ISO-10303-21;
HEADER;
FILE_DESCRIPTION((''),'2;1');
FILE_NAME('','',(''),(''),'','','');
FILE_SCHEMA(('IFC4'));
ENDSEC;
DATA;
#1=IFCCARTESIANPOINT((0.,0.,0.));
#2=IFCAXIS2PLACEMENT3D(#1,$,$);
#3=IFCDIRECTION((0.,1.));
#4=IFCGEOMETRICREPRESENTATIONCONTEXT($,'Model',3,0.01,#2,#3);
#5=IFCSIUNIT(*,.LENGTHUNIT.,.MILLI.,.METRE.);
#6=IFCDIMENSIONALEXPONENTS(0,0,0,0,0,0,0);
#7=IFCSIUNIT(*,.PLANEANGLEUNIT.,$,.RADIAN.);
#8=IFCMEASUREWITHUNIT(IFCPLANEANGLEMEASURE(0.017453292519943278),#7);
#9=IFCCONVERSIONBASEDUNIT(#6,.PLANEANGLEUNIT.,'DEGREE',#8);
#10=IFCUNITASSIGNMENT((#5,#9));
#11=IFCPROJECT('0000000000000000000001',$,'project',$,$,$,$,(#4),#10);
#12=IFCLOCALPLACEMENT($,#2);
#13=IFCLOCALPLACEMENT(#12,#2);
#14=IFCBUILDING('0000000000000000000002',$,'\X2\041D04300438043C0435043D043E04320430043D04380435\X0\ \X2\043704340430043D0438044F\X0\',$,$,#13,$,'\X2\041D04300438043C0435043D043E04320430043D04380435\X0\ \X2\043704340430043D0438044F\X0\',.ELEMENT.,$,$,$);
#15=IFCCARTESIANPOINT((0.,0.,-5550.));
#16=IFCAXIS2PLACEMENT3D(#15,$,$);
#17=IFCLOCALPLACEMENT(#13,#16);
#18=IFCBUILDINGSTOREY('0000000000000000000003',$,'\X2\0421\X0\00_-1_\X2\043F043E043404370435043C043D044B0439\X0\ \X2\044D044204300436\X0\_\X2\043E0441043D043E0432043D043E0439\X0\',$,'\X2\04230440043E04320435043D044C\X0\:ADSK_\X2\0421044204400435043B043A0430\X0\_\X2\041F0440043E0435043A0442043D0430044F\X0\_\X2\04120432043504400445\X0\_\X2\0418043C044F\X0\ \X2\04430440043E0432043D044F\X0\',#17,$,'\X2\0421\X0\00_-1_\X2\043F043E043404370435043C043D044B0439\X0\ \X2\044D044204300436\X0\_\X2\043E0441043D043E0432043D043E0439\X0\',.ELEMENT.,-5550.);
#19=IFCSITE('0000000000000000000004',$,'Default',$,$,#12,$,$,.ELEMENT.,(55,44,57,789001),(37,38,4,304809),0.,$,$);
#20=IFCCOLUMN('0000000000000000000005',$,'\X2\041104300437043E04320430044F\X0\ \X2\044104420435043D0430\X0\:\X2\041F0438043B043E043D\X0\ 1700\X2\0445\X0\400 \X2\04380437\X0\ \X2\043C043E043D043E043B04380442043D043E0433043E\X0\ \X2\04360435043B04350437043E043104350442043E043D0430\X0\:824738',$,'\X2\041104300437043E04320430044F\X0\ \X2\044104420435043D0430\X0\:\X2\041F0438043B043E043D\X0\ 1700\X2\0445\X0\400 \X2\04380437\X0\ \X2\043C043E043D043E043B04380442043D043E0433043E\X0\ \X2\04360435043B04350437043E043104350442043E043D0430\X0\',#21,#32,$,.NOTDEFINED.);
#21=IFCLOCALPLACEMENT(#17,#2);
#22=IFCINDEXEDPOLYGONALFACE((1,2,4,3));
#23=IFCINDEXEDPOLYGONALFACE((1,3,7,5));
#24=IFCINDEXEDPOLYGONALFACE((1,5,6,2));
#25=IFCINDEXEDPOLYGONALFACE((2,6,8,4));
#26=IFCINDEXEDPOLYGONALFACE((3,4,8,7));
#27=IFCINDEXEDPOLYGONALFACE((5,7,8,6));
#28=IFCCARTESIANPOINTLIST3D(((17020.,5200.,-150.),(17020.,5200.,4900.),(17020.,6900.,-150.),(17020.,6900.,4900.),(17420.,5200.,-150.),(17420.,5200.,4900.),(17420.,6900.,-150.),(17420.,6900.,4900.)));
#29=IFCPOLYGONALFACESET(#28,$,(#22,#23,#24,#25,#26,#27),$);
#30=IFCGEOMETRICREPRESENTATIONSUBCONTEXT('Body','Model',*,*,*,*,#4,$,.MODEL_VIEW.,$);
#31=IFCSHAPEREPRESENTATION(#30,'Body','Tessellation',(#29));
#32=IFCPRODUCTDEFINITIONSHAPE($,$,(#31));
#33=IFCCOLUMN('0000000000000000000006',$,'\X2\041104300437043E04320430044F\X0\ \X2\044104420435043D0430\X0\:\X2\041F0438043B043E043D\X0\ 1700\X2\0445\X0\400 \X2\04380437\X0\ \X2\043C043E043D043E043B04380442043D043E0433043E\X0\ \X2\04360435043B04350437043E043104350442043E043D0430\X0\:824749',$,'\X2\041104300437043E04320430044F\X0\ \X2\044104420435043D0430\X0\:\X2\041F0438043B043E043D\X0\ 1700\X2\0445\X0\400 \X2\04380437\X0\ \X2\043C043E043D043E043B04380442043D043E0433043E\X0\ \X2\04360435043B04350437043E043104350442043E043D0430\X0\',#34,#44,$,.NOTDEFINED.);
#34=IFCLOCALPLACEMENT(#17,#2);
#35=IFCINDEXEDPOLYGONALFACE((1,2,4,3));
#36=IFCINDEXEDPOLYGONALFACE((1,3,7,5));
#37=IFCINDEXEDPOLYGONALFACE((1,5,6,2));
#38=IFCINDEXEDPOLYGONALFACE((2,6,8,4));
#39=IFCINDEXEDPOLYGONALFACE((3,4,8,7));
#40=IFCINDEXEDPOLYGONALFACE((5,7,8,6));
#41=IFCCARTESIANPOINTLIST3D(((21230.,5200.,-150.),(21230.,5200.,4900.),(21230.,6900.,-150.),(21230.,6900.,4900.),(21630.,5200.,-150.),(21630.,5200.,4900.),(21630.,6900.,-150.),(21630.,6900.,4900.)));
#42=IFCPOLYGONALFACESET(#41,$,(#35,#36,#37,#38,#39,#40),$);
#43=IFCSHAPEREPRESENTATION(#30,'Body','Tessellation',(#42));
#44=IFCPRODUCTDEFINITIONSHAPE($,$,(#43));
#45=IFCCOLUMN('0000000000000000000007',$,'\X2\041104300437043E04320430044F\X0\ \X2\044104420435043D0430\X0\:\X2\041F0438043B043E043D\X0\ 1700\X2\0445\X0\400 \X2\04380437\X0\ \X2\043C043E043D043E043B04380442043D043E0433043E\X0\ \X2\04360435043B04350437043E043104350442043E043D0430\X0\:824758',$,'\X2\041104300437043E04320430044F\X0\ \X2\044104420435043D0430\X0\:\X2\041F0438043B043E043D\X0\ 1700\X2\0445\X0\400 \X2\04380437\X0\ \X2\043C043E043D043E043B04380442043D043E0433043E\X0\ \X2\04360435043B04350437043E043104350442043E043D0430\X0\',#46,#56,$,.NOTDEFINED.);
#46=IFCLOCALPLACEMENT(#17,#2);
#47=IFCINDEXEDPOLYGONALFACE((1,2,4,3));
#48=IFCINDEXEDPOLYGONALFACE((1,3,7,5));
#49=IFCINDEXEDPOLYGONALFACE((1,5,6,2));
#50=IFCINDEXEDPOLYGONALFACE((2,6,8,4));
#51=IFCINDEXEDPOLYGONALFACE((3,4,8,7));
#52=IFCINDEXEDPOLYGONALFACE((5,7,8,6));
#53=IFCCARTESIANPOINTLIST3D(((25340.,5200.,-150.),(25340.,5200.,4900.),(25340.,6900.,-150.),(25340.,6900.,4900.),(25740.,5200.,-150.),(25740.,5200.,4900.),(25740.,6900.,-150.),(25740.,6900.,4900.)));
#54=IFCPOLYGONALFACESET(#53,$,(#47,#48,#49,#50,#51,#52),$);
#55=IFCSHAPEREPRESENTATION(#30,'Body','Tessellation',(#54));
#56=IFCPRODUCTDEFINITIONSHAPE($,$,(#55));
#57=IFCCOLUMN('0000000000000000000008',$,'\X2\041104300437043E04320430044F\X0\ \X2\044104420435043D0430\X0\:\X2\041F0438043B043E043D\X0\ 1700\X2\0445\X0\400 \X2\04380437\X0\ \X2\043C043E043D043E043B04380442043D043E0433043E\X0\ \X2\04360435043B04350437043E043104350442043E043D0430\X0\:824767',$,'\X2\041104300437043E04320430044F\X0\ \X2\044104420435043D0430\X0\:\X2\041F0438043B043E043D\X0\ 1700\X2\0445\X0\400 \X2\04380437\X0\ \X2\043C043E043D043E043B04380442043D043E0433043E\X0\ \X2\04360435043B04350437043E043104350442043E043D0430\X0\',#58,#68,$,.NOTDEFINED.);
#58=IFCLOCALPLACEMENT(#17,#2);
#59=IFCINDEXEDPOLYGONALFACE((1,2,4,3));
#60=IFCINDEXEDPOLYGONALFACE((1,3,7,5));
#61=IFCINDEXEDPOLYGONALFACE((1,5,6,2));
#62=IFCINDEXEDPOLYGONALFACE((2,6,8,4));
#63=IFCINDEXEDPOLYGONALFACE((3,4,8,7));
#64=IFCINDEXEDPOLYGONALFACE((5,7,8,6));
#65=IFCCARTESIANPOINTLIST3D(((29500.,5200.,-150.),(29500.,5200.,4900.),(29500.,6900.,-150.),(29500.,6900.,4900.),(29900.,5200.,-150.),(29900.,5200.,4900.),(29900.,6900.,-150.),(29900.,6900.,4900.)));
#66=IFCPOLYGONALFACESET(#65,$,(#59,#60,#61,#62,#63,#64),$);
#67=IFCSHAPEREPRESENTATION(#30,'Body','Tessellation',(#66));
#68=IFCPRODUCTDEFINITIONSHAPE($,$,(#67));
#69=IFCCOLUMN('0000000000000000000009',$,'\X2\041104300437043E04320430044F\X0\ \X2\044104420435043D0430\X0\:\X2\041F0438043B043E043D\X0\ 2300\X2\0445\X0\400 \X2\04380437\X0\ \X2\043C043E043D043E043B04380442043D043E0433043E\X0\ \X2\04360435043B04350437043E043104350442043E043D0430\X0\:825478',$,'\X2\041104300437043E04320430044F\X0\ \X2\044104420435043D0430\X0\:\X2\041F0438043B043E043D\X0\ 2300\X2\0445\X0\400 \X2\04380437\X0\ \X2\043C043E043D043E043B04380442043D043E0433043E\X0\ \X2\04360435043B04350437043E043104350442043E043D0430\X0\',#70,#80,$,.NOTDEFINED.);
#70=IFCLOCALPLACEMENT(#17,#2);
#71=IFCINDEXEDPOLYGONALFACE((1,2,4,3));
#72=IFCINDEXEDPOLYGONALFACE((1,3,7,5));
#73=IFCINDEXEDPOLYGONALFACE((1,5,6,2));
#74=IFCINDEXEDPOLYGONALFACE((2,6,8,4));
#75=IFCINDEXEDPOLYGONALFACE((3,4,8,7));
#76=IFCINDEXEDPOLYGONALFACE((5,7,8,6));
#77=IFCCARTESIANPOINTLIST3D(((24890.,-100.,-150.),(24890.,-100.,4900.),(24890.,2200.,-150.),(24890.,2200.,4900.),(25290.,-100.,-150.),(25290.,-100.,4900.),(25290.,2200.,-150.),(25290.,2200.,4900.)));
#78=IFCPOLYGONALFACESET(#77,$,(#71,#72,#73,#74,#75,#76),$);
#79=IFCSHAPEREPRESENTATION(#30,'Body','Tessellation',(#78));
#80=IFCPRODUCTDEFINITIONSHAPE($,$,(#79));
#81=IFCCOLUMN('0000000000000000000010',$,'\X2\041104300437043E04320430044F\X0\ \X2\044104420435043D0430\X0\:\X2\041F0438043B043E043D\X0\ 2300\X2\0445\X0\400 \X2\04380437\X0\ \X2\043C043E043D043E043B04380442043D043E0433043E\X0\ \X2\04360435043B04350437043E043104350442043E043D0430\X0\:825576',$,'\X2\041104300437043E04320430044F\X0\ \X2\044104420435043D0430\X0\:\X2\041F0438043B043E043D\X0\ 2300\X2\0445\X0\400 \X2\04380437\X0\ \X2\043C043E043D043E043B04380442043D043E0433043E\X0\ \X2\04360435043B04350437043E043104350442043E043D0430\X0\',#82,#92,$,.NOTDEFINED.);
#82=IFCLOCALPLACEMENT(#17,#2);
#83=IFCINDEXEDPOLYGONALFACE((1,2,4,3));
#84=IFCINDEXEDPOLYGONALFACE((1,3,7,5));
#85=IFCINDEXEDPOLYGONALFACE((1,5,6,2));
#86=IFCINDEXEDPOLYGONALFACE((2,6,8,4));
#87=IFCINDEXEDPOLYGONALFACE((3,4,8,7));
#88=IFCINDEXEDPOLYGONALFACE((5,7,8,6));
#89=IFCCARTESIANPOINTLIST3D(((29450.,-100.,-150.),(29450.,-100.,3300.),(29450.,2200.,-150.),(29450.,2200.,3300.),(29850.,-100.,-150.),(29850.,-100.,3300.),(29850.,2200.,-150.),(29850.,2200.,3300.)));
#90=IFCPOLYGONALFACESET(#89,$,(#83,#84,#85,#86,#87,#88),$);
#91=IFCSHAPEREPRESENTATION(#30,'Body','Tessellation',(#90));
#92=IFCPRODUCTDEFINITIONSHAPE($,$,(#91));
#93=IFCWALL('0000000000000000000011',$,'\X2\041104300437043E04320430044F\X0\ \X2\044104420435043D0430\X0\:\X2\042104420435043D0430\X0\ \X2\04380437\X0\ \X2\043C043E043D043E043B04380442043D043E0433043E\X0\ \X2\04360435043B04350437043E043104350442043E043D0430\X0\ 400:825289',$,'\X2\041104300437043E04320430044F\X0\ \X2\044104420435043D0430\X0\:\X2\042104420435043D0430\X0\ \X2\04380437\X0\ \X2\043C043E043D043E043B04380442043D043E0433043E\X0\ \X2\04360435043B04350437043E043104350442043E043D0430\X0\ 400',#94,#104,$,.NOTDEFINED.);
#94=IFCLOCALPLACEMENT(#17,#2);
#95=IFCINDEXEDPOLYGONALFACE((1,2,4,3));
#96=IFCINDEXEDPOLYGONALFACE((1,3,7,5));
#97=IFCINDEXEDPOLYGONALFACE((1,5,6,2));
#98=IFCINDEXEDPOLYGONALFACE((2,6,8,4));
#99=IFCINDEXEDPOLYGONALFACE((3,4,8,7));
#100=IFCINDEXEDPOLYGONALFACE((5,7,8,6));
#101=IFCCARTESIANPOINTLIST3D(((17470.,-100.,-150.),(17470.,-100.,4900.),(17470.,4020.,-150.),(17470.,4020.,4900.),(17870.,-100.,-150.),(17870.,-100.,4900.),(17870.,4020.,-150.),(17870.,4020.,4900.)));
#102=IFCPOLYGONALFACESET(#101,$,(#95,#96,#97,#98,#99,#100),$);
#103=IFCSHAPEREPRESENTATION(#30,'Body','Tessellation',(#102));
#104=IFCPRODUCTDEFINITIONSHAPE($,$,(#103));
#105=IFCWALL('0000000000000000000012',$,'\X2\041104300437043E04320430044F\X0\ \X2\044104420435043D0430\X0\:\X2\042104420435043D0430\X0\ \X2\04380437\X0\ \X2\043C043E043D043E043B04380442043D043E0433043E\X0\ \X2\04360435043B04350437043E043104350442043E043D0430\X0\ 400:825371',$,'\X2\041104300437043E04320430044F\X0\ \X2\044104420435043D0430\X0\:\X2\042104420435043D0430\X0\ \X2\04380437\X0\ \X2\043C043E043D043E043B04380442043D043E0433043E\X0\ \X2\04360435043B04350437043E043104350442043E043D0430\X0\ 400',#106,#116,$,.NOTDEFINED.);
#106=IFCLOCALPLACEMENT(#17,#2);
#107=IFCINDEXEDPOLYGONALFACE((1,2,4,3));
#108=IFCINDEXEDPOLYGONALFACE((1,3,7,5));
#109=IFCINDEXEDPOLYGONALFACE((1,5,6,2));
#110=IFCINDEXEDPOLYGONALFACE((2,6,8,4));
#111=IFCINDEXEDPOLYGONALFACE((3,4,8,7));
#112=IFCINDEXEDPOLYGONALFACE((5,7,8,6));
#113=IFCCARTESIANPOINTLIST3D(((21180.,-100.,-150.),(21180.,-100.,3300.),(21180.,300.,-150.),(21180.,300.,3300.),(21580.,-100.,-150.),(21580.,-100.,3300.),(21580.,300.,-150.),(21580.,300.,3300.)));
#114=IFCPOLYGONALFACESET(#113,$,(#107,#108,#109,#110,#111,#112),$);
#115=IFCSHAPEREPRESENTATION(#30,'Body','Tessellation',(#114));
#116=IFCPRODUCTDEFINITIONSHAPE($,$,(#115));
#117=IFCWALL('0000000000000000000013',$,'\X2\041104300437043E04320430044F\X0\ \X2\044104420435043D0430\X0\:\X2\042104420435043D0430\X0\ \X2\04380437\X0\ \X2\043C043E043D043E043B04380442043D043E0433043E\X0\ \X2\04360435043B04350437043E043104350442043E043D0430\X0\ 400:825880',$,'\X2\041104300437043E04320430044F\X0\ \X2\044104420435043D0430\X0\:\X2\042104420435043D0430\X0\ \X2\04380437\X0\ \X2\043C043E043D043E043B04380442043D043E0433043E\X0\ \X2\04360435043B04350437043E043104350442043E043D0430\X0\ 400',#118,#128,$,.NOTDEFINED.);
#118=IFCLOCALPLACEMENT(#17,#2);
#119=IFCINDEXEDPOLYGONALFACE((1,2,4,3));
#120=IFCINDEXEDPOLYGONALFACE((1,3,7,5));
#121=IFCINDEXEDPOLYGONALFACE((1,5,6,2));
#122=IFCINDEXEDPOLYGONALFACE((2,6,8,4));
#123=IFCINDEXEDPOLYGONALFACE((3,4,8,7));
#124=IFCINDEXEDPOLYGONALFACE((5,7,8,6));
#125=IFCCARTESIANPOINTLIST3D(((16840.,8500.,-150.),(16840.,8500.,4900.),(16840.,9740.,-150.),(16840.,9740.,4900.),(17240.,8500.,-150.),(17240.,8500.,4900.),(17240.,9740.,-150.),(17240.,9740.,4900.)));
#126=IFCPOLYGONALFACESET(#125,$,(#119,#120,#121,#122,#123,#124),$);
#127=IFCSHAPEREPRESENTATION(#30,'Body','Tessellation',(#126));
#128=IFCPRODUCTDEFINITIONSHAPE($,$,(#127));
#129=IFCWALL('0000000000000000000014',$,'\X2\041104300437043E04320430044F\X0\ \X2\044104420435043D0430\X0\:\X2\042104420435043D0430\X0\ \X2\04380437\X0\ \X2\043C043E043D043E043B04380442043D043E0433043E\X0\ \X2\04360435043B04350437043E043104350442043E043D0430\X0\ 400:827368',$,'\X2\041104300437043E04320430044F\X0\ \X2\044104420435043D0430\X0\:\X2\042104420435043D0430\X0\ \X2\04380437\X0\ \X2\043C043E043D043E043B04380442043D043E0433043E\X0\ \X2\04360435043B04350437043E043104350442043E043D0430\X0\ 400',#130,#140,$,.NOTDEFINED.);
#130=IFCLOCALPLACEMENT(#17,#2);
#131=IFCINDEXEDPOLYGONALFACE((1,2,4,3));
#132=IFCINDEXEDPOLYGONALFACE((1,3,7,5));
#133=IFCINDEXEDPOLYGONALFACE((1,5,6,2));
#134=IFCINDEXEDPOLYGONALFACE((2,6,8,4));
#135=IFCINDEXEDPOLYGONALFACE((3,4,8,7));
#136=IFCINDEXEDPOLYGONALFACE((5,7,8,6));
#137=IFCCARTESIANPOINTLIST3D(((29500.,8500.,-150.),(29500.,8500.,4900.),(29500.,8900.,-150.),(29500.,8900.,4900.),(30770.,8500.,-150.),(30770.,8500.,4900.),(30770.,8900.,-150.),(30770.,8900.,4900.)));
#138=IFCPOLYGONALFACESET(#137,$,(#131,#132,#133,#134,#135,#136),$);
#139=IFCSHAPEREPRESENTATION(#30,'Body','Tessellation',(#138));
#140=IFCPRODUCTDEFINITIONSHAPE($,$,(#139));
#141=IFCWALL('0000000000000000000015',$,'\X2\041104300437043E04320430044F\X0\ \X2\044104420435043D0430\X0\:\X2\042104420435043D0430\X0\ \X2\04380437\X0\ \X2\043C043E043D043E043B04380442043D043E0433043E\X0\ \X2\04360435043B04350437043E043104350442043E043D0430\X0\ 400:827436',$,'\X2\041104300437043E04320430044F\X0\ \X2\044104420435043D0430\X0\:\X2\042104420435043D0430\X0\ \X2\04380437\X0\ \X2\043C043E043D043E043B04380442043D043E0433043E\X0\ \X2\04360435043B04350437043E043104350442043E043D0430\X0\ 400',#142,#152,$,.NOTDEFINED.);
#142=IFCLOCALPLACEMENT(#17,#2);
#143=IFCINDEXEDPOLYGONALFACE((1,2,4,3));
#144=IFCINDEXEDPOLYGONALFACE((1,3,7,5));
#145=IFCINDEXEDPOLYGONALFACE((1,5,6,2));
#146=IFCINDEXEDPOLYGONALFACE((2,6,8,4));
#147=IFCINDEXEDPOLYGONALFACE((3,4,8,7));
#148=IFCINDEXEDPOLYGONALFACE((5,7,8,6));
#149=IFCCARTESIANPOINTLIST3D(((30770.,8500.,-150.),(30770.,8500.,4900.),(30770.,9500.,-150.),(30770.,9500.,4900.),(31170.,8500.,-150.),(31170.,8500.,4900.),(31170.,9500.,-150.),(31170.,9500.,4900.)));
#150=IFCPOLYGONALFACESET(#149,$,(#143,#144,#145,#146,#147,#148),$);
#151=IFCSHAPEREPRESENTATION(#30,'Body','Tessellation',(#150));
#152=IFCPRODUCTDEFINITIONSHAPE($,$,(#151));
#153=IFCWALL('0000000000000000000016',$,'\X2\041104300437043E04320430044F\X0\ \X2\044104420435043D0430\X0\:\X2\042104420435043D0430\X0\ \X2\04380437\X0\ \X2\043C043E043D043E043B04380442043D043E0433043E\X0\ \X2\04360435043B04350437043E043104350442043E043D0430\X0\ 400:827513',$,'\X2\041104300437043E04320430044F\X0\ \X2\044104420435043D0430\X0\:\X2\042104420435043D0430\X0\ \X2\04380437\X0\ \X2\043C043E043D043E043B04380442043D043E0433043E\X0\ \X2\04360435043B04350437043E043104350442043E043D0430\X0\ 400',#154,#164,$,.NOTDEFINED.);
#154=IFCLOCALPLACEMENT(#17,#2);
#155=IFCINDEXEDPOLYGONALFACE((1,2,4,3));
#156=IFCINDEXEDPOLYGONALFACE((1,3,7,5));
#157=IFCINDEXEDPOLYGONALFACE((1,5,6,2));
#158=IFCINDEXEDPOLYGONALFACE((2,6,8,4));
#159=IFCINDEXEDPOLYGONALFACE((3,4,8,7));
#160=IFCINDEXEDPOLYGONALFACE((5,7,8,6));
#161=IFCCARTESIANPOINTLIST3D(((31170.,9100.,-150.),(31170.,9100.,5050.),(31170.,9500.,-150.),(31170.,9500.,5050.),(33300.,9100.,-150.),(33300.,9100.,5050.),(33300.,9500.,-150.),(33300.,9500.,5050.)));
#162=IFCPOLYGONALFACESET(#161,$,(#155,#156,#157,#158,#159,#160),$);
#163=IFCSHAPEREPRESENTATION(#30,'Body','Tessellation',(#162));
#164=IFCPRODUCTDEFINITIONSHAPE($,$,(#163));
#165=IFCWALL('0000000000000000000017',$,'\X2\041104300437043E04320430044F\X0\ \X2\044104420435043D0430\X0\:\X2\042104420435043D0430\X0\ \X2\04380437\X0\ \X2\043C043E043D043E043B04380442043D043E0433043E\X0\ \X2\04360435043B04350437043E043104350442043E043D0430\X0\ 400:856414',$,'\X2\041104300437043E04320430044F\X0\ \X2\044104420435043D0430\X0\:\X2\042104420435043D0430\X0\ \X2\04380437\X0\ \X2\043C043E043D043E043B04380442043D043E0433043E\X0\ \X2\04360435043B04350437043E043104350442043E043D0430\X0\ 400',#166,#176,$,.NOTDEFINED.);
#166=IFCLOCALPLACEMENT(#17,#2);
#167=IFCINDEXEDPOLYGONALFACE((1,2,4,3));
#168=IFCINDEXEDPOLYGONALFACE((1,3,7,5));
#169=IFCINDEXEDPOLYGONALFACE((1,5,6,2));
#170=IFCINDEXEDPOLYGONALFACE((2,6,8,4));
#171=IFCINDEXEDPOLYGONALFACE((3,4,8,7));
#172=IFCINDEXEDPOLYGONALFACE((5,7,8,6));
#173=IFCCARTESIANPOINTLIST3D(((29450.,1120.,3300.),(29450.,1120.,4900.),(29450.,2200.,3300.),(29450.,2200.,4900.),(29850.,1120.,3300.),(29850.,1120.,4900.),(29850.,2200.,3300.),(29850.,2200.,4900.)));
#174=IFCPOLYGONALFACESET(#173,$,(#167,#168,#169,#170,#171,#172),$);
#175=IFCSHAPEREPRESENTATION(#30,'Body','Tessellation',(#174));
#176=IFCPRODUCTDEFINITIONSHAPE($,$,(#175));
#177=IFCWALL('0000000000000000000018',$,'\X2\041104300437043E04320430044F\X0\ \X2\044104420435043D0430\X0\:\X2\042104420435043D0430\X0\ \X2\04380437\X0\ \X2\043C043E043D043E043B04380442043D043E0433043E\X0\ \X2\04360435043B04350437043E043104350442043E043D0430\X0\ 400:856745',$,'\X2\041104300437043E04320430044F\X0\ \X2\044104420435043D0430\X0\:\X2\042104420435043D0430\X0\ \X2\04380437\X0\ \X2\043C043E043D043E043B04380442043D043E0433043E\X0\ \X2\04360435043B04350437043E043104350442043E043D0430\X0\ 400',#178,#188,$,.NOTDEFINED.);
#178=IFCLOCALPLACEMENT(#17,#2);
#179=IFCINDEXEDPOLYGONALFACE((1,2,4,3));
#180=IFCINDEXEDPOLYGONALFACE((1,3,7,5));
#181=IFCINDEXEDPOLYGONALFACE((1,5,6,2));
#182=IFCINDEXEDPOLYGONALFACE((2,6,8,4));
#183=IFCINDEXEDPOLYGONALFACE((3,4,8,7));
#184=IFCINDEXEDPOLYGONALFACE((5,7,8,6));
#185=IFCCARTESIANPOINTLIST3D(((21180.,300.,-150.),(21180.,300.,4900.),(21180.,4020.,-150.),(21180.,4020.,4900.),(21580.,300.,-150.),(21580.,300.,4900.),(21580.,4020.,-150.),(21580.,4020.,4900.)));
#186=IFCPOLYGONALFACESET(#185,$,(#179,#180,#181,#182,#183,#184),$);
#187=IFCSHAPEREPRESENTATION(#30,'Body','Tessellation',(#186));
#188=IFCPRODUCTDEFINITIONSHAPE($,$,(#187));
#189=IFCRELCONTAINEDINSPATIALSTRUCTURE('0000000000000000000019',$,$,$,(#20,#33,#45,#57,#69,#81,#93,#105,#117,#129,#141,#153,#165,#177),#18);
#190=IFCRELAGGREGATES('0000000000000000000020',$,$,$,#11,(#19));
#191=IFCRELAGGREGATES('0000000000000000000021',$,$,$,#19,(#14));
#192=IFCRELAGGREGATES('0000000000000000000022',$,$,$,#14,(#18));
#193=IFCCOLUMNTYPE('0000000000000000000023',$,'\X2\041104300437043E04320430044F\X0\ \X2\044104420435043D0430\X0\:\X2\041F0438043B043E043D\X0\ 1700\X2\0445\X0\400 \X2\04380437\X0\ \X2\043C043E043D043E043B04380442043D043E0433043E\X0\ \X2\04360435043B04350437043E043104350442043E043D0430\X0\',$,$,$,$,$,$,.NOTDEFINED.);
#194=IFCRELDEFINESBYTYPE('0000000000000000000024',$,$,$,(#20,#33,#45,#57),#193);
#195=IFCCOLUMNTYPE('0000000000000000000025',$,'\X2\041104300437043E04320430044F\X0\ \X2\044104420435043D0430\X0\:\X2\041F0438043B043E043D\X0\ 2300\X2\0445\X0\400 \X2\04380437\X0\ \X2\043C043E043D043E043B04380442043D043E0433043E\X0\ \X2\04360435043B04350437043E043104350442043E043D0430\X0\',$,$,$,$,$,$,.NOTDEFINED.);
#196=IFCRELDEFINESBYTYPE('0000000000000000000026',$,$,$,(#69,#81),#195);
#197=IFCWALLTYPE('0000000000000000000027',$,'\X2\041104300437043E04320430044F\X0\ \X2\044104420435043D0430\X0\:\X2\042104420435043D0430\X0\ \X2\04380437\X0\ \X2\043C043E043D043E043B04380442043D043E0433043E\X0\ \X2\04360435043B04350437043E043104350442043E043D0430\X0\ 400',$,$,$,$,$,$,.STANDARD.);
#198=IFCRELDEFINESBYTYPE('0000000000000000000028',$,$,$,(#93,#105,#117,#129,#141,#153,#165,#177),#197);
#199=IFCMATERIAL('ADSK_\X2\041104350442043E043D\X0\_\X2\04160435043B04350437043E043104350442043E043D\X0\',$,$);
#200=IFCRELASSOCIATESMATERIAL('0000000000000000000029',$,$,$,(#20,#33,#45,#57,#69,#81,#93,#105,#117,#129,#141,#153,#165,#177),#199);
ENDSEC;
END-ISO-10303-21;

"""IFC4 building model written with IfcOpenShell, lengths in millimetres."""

from ifc_helpers import new_model, entity, si_unit, converted_unit, direction, frame, origin, place, context, subcontext, project, spatial, indexed_curve, outline, extrude, material, type_object, element, save


model = new_model("IFC4")

# Units and contexts
model_context = context("Model", 3, precision=0.01, world=origin(), true_north=direction((0.0, 1.0)))
body_context = subcontext(model_context, "Body", "Model", "MODEL_VIEW")
ifc_project = project(units=[si_unit("LENGTHUNIT", "METRE", prefix="MILLI"), converted_unit("PLANEANGLEUNIT", "DEGREE", entity("IfcPlaneAngleMeasure", 0.017453292519943278), si_unit("PLANEANGLEUNIT", "RADIAN"), dimensions=[0, 0, 0, 0, 0, 0, 0])], contexts=[model_context])

# Site, building, storey
site_placement = place(None, origin())
site = spatial("IfcSite", under=ifc_project, at=site_placement, Name="Default", CompositionType="ELEMENT", RefLatitude=(55, 44, 57, 789001), RefLongitude=(37, 38, 4, 304809), RefElevation=0.0)
building_placement = place(site_placement, origin())
building = spatial("IfcBuilding", under=site, at=building_placement, Name="Наименование здания", LongName="Наименование здания", CompositionType="ELEMENT")
storey_placement = place(building_placement, frame((0.0, 0.0, -5550.0)))
storey = spatial("IfcBuildingStorey", under=building, at=storey_placement, Name="С00_-1_подземный этаж_основной", ObjectType="Уровень:ADSK_Стрелка_Проектная_Вверх_Имя уровня", LongName="С00_-1_подземный этаж_основной", CompositionType="ELEMENT", Elevation=-5550.0)

# Columns
ifc_material_1 = material(Name="ADSK_Бетон_Железобетон")
column_type_1 = type_object("IfcColumnType", Name="Базовая стена:Пилон 1700х400 из монолитного железобетона", PredefinedType="NOTDEFINED")
column_1_placement = place(storey_placement, frame((17220.0, 5200.0, -150.0), z_axis=(0.0, 0.0, 1.0), x_axis=(0.0, 1.0, 0.0)))
element("IfcColumn", 1, at=column_1_placement, inside=storey, type_object=column_type_1, material=ifc_material_1, Name="Базовая стена:Пилон 1700х400 из монолитного железобетона:824738", ObjectType="Базовая стена:Пилон 1700х400 из монолитного железобетона", PredefinedType="NOTDEFINED", context=body_context, shape_type="SweptSolid", body=[
    extrude(outline(indexed_curve([(1700.0, 200.0), (0.0, 200.0), (0.0, -200.0), (1700.0, -200.0), (1700.0, 200.0)], self_intersect=False)), origin(), (0.0, 0.0, 1.0), 5050.0),
])
column_2_placement = place(storey_placement, frame((21430.0, 5200.0, -150.0), z_axis=(0.0, 0.0, 1.0), x_axis=(0.0, 1.0, 0.0)))
element("IfcColumn", 2, at=column_2_placement, inside=storey, type_object=column_type_1, material=ifc_material_1, Name="Базовая стена:Пилон 1700х400 из монолитного железобетона:824749", ObjectType="Базовая стена:Пилон 1700х400 из монолитного железобетона", PredefinedType="NOTDEFINED", context=body_context, shape_type="SweptSolid", body=[
    extrude(outline(indexed_curve([(1700.0, 200.0), (0.0, 200.0), (0.0, -200.0), (1700.0, -200.0), (1700.0, 200.0)], self_intersect=False)), origin(), (0.0, 0.0, 1.0), 5050.0),
])
for number, where, z_axis, x_axis, name in (
    (3, (25540.0, 5200.0, -150.0), (0.0, 0.0, 1.0), (0.0, 1.0, 0.0), "Базовая стена:Пилон 1700х400 из монолитного железобетона:824758"),
    (4, (29700.0, 5200.0, -150.0), (0.0, 0.0, 1.0), (0.0, 1.0, 0.0), "Базовая стена:Пилон 1700х400 из монолитного железобетона:824767"),
):
    element("IfcColumn", number, at=place(storey_placement, frame(where, z_axis=z_axis, x_axis=x_axis)), inside=storey, type_object=column_type_1, material=ifc_material_1, Name=name, ObjectType="Базовая стена:Пилон 1700х400 из монолитного железобетона", PredefinedType="NOTDEFINED", context=body_context, shape_type="SweptSolid", body=[
        extrude(outline(indexed_curve([(1700.0, 200.0), (0.0, 200.0), (0.0, -200.0), (1700.0, -200.0), (1700.0, 200.0)], self_intersect=False)), origin(), (0.0, 0.0, 1.0), 5050.0),
    ])
column_type_2 = type_object("IfcColumnType", Name="Базовая стена:Пилон 2300х400 из монолитного железобетона", PredefinedType="NOTDEFINED")
column_3_placement = place(storey_placement, frame((25090.0, 2200.0, -150.0), z_axis=(0.0, 0.0, 1.0), x_axis=(0.0, -1.0, 0.0)))
element("IfcColumn", 5, at=column_3_placement, inside=storey, type_object=column_type_2, material=ifc_material_1, Name="Базовая стена:Пилон 2300х400 из монолитного железобетона:825478", ObjectType="Базовая стена:Пилон 2300х400 из монолитного железобетона", PredefinedType="NOTDEFINED", context=body_context, shape_type="SweptSolid", body=[
    extrude(outline(indexed_curve([(2300.0, 200.0), (0.0, 200.0), (0.0, -200.0), (2300.0, -200.0), (2300.0, 200.0)], self_intersect=False)), origin(), (0.0, 0.0, 1.0), 5050.0),
])
column_4_placement = place(storey_placement, frame((29650.0, 2200.0, -150.0), z_axis=(0.0, 0.0, 1.0), x_axis=(0.0, -1.0, 0.0)))
element("IfcColumn", 6, at=column_4_placement, inside=storey, type_object=column_type_2, material=ifc_material_1, Name="Базовая стена:Пилон 2300х400 из монолитного железобетона:825576", ObjectType="Базовая стена:Пилон 2300х400 из монолитного железобетона", PredefinedType="NOTDEFINED", context=body_context, shape_type="SweptSolid", body=[
    extrude(outline(indexed_curve([(2300.0, 200.0), (0.0, 200.0), (0.0, -200.0), (2300.0, -200.0), (2300.0, 200.0)], self_intersect=False)), origin(), (0.0, 0.0, 1.0), 3450.0),
])

# Walls
wall_type_1 = type_object("IfcWallType", Name="Базовая стена:Стена из монолитного железобетона 400", PredefinedType="STANDARD")
wall_1_placement = place(storey_placement, frame((17670.0, 4020.0, -150.0), z_axis=(0.0, 0.0, 1.0), x_axis=(0.0, -1.0, 0.0)))
element("IfcWall", 7, at=wall_1_placement, inside=storey, type_object=wall_type_1, material=ifc_material_1, Name="Базовая стена:Стена из монолитного железобетона 400:825289", ObjectType="Базовая стена:Стена из монолитного железобетона 400", PredefinedType="NOTDEFINED", context=body_context, shape_type="SweptSolid", body=[
    extrude(outline(indexed_curve([(4120.0, 200.0), (0.0, 200.0), (0.0, -200.0), (4120.0, -200.0), (4120.0, 200.0)], self_intersect=False)), origin(), (0.0, 0.0, 1.0), 5050.0),
])
wall_2_placement = place(storey_placement, frame((21380.0, -100.0, -150.0), z_axis=(0.0, 0.0, 1.0), x_axis=(0.0, 1.0, 0.0)))
element("IfcWall", 8, at=wall_2_placement, inside=storey, type_object=wall_type_1, material=ifc_material_1, Name="Базовая стена:Стена из монолитного железобетона 400:825371", ObjectType="Базовая стена:Стена из монолитного железобетона 400", PredefinedType="NOTDEFINED", context=body_context, shape_type="SweptSolid", body=[
    extrude(outline(indexed_curve([(400.0, 200.0), (0.0, 200.0), (0.0, -200.0), (400.0, -200.0), (400.0, 200.0)], self_intersect=False)), origin(), (0.0, 0.0, 1.0), 3450.0),
])
wall_3_placement = place(storey_placement, frame((17040.0, 9740.0, -150.0), z_axis=(0.0, 0.0, 1.0), x_axis=(0.0, -1.0, 0.0)))
element("IfcWall", 9, at=wall_3_placement, inside=storey, type_object=wall_type_1, material=ifc_material_1, Name="Базовая стена:Стена из монолитного железобетона 400:825880", ObjectType="Базовая стена:Стена из монолитного железобетона 400", PredefinedType="NOTDEFINED", context=body_context, shape_type="SweptSolid", body=[
    extrude(outline(indexed_curve([(1240.0, 200.0), (0.0, 200.0), (0.0, -200.0), (1240.0, -200.0), (1240.0, 200.0)], self_intersect=False)), origin(), (0.0, 0.0, 1.0), 5050.0),
])
wall_4_placement = place(storey_placement, frame((29500.0, 8700.0, -150.0)))
element("IfcWall", 10, at=wall_4_placement, inside=storey, type_object=wall_type_1, material=ifc_material_1, Name="Базовая стена:Стена из монолитного железобетона 400:827368", ObjectType="Базовая стена:Стена из монолитного железобетона 400", PredefinedType="NOTDEFINED", context=body_context, shape_type="SweptSolid", body=[
    extrude(outline(indexed_curve([(1270.0, 200.0), (0.0, 200.0), (0.0, -200.0), (1270.0, -200.0), (1270.0, 200.0)], self_intersect=False)), origin(), (0.0, 0.0, 1.0), 5050.0),
])
wall_5_placement = place(storey_placement, frame((30970.0, 8500.0, -150.0), z_axis=(0.0, 0.0, 1.0), x_axis=(0.0, 1.0, 0.0)))
element("IfcWall", 11, at=wall_5_placement, inside=storey, type_object=wall_type_1, material=ifc_material_1, Name="Базовая стена:Стена из монолитного железобетона 400:827436", ObjectType="Базовая стена:Стена из монолитного железобетона 400", PredefinedType="NOTDEFINED", context=body_context, shape_type="SweptSolid", body=[
    extrude(outline(indexed_curve([(1000.0, 200.0), (0.0, 200.0), (0.0, -200.0), (1000.0, -200.0), (1000.0, 200.0)], self_intersect=False)), origin(), (0.0, 0.0, 1.0), 5050.0),
])
wall_6_placement = place(storey_placement, frame((31170.0, 9300.0, -150.0)))
element("IfcWall", 12, at=wall_6_placement, inside=storey, type_object=wall_type_1, material=ifc_material_1, Name="Базовая стена:Стена из монолитного железобетона 400:827513", ObjectType="Базовая стена:Стена из монолитного железобетона 400", PredefinedType="NOTDEFINED", context=body_context, shape_type="SweptSolid", body=[
    extrude(outline(indexed_curve([(2130.0, 200.0), (0.0, 200.0), (0.0, -200.0), (2130.0, -200.0), (2130.0, 200.0)], self_intersect=False)), origin(), (0.0, 0.0, 1.0), 5200.0),
])
wall_7_placement = place(storey_placement, frame((29650.0, 2200.0, 3300.0), z_axis=(0.0, 0.0, 1.0), x_axis=(0.0, -1.0, 0.0)))
element("IfcWall", 13, at=wall_7_placement, inside=storey, type_object=wall_type_1, material=ifc_material_1, Name="Базовая стена:Стена из монолитного железобетона 400:856414", ObjectType="Базовая стена:Стена из монолитного железобетона 400", PredefinedType="NOTDEFINED", context=body_context, shape_type="SweptSolid", body=[
    extrude(outline(indexed_curve([(1080.0, 200.0), (0.0, 200.0), (0.0, -200.0), (1080.0, -200.0), (1080.0, 200.0)], self_intersect=False)), origin(), (0.0, 0.0, 1.0), 1600.0),
])
wall_8_placement = place(storey_placement, frame((21380.0, 300.0, -150.0), z_axis=(0.0, 0.0, 1.0), x_axis=(0.0, 1.0, 0.0)))
element("IfcWall", 14, at=wall_8_placement, inside=storey, type_object=wall_type_1, material=ifc_material_1, Name="Базовая стена:Стена из монолитного железобетона 400:856745", ObjectType="Базовая стена:Стена из монолитного железобетона 400", PredefinedType="NOTDEFINED", context=body_context, shape_type="SweptSolid", body=[
    extrude(outline(indexed_curve([(3720.0, 200.0), (0.0, 200.0), (0.0, -200.0), (3720.0, -200.0), (3720.0, 200.0)], self_intersect=False)), origin(), (0.0, 0.0, 1.0), 5050.0),
])

save(model, "model.ifc")
